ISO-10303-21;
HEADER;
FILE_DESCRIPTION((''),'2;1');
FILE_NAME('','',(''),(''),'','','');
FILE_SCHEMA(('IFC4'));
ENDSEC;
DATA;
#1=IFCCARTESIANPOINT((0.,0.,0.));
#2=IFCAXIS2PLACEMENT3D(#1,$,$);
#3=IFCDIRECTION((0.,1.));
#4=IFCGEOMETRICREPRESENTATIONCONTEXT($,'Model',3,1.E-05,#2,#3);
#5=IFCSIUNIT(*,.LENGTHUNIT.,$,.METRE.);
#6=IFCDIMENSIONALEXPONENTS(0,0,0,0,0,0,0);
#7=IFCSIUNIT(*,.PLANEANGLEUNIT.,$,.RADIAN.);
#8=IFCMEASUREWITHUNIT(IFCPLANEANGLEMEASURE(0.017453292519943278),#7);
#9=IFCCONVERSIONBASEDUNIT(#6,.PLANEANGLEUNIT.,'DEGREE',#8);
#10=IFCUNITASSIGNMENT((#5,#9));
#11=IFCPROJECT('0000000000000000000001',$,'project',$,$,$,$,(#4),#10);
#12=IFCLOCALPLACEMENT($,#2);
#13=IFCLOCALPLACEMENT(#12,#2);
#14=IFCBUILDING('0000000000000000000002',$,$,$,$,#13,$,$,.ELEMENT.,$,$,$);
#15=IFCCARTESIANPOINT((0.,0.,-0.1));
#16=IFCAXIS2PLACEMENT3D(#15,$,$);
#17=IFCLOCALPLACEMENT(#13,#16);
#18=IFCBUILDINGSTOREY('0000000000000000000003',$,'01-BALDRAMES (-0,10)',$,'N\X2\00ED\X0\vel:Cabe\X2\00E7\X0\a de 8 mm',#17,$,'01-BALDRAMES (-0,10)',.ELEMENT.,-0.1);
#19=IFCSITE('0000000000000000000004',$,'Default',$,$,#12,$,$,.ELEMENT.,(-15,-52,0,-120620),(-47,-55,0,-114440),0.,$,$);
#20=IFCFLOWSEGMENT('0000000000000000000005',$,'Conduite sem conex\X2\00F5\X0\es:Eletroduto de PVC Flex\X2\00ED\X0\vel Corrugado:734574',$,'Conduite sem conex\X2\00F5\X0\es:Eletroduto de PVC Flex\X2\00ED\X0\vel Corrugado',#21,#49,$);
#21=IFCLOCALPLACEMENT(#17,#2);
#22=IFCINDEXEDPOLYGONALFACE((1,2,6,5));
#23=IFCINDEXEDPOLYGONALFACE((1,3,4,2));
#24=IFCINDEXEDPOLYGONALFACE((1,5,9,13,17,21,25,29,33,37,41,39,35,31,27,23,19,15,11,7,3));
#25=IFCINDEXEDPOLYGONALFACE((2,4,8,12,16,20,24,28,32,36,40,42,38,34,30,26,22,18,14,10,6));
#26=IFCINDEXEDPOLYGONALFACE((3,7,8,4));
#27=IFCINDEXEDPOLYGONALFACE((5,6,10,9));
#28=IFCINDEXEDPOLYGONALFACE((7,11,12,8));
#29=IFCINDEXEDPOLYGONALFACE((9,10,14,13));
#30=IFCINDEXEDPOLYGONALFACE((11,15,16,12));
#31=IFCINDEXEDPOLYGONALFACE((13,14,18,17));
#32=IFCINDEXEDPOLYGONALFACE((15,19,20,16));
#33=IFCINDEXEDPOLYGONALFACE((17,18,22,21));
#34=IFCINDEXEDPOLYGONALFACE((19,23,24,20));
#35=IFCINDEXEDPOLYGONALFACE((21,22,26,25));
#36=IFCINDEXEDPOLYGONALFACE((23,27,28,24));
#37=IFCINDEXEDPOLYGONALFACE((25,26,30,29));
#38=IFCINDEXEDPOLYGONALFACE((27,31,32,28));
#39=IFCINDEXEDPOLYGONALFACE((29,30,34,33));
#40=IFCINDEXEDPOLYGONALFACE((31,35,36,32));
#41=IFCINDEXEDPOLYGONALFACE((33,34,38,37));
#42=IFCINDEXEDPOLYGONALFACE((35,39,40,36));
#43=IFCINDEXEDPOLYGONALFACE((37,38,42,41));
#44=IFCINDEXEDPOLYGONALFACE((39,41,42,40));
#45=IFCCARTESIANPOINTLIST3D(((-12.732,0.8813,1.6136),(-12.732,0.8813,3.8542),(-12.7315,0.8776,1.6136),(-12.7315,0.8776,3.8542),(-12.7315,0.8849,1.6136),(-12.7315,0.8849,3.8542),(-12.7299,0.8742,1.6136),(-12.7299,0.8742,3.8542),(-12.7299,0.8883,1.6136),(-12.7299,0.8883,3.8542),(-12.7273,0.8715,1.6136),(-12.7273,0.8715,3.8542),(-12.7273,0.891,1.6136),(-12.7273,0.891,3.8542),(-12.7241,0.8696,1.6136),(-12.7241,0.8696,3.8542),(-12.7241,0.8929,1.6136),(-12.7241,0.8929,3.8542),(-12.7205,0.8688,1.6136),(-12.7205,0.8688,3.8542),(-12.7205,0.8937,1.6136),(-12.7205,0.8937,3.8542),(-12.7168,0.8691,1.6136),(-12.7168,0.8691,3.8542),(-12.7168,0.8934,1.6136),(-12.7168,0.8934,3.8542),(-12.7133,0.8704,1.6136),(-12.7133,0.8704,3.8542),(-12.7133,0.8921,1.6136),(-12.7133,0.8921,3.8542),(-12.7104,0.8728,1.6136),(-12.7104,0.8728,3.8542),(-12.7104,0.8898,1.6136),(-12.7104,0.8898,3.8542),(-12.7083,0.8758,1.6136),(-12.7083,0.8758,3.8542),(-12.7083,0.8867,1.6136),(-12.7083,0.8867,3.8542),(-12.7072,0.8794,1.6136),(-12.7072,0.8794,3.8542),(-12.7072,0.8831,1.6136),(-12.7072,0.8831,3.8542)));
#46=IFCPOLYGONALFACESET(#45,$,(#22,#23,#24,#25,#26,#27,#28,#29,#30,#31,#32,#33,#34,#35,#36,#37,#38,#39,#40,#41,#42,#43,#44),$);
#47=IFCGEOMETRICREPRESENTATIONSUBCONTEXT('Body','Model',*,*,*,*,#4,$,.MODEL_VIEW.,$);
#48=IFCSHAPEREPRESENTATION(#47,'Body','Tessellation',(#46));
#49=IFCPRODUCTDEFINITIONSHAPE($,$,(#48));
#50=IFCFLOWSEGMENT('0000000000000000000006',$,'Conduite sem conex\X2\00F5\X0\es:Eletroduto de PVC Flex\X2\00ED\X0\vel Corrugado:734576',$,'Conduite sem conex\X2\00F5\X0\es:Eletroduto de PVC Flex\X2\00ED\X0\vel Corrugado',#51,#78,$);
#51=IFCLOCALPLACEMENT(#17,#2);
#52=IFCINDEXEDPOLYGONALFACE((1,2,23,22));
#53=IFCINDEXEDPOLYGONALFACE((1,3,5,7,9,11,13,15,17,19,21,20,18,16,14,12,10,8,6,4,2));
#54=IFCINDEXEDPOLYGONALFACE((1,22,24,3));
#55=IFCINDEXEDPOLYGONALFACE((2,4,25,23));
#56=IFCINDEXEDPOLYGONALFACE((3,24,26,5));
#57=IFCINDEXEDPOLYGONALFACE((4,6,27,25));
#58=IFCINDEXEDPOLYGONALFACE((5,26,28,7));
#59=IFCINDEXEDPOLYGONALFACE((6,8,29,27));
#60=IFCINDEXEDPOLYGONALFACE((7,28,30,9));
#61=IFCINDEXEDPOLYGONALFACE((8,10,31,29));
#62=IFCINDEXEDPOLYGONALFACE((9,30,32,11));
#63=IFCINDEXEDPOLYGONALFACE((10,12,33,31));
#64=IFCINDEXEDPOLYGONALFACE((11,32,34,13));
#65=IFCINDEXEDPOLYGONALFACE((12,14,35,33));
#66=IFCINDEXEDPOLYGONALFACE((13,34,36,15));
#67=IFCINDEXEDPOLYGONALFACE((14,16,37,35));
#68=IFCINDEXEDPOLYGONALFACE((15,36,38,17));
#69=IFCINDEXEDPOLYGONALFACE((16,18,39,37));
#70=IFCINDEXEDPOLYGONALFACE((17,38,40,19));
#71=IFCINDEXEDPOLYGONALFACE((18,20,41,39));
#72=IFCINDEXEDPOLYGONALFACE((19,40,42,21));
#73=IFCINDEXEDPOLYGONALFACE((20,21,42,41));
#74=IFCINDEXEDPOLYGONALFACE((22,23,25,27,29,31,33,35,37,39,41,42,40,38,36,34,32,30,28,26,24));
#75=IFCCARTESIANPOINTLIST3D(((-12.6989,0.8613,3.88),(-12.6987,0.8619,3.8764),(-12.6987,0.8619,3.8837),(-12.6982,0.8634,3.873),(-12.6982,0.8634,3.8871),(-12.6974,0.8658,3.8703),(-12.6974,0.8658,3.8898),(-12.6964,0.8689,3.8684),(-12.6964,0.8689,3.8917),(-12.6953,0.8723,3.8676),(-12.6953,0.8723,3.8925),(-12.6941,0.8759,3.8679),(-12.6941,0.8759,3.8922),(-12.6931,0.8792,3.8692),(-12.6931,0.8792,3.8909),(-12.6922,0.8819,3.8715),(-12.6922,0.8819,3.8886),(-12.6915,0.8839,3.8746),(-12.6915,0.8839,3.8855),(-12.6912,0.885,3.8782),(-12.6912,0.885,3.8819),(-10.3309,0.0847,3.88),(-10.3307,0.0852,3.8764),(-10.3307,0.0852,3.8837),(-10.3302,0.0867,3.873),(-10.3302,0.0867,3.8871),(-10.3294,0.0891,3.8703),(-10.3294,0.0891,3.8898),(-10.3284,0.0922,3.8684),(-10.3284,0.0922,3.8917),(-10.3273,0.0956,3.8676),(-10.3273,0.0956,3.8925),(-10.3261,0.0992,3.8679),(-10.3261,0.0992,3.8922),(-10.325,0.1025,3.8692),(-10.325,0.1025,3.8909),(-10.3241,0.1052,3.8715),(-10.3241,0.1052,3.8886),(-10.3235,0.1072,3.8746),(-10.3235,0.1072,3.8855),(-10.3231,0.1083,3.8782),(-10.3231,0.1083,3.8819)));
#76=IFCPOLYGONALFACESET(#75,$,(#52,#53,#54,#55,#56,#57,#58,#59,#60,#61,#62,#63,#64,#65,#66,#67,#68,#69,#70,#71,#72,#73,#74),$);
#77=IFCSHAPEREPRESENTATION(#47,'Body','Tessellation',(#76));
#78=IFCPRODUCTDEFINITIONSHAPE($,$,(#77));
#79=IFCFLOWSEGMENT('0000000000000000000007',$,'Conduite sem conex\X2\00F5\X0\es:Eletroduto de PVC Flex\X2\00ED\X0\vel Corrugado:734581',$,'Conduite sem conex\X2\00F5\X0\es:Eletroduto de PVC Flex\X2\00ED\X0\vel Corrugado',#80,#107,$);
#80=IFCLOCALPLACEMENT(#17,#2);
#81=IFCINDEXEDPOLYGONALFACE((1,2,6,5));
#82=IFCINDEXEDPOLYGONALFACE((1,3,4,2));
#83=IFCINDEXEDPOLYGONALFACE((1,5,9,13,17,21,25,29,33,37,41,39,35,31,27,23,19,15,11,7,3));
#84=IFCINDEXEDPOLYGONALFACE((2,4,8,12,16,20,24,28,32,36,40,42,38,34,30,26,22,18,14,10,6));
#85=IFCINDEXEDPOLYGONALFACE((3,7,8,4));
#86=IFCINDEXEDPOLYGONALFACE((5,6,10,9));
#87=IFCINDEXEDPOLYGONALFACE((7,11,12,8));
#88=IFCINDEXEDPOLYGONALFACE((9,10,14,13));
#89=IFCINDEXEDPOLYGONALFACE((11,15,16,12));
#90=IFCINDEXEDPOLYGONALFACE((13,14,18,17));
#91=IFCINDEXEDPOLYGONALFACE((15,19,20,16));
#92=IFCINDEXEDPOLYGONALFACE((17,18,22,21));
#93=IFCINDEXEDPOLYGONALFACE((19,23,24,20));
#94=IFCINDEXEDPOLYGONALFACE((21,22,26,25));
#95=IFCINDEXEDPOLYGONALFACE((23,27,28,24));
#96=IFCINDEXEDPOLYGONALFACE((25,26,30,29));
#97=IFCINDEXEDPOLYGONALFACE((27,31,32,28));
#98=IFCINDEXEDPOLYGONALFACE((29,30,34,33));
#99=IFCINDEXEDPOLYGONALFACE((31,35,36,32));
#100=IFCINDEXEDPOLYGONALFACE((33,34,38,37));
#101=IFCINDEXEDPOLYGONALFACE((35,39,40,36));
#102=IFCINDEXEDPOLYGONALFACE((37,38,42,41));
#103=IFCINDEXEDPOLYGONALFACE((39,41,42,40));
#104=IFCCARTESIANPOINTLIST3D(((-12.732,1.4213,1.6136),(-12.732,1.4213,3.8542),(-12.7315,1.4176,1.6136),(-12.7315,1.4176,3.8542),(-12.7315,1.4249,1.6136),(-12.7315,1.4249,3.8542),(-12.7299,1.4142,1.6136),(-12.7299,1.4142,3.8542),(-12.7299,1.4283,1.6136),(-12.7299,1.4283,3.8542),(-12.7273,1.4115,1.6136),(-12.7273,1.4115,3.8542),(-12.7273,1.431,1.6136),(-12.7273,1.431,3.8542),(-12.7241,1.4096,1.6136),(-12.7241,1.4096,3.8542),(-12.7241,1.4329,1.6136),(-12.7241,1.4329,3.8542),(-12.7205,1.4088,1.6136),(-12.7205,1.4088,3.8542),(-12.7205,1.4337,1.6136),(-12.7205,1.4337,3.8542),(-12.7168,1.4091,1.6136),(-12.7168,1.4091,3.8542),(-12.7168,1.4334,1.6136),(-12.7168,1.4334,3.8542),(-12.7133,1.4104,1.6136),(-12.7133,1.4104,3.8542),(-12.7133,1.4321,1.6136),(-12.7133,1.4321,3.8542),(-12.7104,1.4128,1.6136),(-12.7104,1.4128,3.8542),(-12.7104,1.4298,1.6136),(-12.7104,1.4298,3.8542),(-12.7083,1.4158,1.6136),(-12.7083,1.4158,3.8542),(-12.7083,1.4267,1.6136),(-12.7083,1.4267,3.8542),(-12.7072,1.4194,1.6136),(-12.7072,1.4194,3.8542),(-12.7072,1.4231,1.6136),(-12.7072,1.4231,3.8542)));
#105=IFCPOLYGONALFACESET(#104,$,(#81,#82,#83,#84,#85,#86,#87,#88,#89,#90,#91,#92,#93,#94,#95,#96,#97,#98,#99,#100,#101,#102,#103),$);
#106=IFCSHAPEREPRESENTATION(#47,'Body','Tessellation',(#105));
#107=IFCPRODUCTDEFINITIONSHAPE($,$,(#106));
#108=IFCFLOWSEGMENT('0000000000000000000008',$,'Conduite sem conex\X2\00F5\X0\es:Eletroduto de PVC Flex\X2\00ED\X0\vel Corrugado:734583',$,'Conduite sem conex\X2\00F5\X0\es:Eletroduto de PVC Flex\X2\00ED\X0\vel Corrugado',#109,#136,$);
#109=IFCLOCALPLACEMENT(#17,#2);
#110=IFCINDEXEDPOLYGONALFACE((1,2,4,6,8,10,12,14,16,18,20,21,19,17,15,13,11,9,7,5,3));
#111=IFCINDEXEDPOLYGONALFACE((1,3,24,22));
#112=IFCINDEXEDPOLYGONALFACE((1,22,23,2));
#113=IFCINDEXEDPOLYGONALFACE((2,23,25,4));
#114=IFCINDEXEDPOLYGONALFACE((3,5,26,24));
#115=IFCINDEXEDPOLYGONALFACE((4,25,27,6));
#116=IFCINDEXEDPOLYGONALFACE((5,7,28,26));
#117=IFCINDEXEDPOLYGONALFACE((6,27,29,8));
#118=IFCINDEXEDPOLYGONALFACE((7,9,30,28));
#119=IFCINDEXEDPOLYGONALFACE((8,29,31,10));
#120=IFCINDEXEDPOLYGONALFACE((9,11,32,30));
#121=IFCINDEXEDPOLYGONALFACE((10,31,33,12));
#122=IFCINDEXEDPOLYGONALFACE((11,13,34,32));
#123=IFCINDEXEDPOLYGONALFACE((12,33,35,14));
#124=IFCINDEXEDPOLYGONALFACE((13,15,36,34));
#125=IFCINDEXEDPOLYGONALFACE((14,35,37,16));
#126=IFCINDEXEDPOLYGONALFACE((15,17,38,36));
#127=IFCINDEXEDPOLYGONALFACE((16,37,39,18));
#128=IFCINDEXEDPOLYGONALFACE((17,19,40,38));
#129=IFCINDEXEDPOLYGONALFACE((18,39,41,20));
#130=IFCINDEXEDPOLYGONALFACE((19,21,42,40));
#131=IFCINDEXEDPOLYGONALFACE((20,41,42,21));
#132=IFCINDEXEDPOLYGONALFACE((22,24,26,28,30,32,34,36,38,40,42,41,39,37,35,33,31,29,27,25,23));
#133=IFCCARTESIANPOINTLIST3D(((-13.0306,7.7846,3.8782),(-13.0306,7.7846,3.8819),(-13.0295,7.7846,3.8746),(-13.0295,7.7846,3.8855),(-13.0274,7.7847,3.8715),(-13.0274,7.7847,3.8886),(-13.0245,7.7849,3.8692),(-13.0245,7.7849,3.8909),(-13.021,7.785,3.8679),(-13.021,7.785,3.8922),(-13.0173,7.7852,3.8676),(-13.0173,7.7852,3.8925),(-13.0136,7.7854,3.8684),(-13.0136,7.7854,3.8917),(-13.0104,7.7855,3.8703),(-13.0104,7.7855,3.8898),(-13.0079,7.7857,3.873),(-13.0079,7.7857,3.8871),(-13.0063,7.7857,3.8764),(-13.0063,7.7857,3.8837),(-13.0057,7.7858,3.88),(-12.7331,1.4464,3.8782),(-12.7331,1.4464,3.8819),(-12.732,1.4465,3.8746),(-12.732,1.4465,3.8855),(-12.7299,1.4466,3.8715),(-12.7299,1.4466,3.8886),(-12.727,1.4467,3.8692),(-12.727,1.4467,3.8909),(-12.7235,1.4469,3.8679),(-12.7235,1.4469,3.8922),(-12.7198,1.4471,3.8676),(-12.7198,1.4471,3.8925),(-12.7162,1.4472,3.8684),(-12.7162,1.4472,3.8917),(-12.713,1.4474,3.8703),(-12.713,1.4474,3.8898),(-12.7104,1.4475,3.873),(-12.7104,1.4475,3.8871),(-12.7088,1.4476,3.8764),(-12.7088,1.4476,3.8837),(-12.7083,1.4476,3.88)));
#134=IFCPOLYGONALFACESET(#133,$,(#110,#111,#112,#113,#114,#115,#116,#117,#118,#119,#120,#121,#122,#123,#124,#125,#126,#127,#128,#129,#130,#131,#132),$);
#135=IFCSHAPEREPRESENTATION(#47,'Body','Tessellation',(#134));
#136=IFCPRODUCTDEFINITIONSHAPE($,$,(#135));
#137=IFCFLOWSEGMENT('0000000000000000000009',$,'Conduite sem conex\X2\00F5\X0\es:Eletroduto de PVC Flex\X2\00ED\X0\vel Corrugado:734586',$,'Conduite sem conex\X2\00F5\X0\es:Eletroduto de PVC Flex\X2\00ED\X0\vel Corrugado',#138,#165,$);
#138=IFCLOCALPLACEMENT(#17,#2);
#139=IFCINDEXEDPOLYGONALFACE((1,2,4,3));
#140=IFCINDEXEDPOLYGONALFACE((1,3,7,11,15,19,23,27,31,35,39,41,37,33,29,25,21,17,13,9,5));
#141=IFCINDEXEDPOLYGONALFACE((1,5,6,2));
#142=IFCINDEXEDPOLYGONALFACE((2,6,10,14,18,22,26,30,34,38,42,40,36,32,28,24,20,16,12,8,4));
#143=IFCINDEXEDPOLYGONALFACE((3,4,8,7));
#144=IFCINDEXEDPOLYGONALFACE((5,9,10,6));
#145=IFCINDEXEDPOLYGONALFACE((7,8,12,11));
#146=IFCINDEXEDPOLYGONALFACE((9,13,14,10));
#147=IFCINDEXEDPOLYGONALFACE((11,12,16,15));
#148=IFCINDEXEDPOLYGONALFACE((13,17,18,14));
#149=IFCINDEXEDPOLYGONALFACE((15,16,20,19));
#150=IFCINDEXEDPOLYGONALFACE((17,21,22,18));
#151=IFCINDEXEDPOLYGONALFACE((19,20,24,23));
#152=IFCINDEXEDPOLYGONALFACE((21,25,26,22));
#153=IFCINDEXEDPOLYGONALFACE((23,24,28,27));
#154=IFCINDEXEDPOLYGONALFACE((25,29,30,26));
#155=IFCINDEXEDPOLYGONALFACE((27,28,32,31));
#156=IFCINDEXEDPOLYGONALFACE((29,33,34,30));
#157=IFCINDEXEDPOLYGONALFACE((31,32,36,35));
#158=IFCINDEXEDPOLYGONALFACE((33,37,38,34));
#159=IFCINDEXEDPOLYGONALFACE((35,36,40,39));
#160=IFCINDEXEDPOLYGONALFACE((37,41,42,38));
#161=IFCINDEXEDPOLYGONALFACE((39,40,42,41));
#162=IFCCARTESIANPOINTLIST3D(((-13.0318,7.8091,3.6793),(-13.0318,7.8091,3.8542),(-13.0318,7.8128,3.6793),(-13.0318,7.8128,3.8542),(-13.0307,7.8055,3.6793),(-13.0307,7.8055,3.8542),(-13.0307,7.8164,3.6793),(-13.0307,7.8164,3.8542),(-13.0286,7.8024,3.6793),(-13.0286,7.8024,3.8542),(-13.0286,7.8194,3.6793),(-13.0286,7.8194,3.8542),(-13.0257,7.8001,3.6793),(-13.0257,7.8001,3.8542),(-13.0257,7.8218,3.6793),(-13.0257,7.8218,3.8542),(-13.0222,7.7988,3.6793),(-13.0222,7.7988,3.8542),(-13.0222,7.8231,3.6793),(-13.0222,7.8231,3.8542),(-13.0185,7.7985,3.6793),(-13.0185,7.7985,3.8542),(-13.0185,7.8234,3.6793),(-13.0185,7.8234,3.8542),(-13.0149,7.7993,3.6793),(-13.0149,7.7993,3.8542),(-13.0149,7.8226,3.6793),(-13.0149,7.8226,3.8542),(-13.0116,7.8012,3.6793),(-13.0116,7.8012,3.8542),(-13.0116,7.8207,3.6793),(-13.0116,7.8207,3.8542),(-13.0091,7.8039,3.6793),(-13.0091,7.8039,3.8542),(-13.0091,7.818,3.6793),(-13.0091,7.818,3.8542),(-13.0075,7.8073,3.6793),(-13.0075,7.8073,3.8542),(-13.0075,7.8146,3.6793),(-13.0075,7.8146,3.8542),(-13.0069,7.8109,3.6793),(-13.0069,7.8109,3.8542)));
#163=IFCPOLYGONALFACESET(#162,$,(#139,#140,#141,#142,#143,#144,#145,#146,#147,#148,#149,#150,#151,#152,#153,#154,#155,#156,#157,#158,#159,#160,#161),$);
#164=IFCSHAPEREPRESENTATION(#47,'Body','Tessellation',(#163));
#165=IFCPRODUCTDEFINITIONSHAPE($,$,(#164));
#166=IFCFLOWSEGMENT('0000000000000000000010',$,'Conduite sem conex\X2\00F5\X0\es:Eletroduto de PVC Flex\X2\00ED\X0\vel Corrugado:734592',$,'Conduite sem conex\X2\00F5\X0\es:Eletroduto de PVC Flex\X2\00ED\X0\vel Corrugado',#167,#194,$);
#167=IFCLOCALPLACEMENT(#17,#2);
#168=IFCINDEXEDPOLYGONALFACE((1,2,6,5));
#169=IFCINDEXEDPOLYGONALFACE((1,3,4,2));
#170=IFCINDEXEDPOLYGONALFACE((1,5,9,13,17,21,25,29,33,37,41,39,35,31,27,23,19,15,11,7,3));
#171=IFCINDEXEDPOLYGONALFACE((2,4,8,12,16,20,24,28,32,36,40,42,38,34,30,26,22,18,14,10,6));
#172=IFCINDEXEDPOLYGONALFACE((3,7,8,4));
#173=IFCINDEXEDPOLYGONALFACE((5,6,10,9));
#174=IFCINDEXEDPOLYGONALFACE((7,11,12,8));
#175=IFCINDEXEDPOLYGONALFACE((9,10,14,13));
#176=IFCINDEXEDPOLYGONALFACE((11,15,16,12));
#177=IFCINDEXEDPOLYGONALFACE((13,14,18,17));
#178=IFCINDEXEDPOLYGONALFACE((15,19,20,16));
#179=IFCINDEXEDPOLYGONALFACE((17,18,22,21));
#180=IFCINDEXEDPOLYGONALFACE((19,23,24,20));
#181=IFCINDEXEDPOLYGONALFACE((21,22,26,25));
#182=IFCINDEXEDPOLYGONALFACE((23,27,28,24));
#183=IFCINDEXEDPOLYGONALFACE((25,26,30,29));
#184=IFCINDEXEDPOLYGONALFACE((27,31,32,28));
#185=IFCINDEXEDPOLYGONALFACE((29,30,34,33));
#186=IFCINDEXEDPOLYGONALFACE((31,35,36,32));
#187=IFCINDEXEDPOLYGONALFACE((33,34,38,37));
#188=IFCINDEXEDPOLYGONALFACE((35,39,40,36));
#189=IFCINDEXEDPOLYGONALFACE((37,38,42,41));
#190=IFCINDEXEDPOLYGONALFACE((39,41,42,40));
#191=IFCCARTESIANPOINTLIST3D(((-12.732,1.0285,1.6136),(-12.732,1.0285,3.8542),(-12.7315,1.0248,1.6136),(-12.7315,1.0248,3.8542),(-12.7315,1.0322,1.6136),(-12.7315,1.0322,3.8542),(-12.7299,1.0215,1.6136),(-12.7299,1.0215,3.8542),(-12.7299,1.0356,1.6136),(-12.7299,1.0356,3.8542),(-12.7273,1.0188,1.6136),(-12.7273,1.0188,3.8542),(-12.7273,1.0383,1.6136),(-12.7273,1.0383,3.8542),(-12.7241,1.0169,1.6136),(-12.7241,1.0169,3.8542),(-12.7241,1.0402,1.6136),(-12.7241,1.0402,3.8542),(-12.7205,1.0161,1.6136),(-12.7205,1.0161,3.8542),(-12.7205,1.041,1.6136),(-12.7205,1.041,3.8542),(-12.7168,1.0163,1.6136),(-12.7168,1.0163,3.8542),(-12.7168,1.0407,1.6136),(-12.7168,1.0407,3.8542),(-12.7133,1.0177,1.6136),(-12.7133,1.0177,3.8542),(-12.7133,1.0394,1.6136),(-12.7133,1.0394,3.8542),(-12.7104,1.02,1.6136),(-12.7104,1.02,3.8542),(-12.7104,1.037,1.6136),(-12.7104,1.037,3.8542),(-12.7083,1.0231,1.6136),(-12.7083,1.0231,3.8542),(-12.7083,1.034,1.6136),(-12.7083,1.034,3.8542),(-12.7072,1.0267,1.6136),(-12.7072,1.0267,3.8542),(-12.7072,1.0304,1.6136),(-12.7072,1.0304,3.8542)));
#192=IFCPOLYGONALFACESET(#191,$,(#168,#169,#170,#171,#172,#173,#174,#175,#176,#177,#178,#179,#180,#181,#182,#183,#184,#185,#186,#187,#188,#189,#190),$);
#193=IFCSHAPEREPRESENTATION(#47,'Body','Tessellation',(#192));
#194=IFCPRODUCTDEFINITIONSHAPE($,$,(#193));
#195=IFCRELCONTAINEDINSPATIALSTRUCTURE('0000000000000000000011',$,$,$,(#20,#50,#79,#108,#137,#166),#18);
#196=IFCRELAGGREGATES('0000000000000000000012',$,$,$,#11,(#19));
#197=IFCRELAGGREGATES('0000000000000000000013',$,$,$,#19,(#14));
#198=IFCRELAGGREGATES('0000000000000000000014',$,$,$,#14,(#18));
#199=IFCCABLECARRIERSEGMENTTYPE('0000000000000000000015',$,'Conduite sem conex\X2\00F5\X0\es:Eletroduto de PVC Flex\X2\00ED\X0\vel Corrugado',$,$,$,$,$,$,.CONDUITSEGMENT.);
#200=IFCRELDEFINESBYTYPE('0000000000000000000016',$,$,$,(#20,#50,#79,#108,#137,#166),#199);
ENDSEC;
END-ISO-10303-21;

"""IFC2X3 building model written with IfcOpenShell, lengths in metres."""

from ifc_helpers import new_model, entity, si_unit, converted_unit, direction, frame, frame_2d, origin, origin_2d_with_axis, place, context, subcontext, project, spatial, circle, extrude, type_object, element, save


model = new_model("IFC2X3")

# Units and contexts
model_context = context("Model", 3, precision=1e-05, world=origin(), true_north=direction((0.0, 1.0)))
body_context = subcontext(model_context, "Body", "Model", "MODEL_VIEW")
ifc_project = project(units=[si_unit("LENGTHUNIT", "METRE"), converted_unit("PLANEANGLEUNIT", "DEGREE", entity("IfcPlaneAngleMeasure", 0.017453292519943278), si_unit("PLANEANGLEUNIT", "RADIAN"), dimensions=[0, 0, 0, 0, 0, 0, 0])], contexts=[model_context])

# Site, building, storey
site_placement = place(None, origin())
site = spatial("IfcSite", under=ifc_project, at=site_placement, Name="Default", CompositionType="ELEMENT", RefLatitude=(-15, -52, 0, -120620), RefLongitude=(-47, -55, 0, -114440), RefElevation=0.0)
building_placement = place(site_placement, origin())
building = spatial("IfcBuilding", under=site, at=building_placement, CompositionType="ELEMENT")
storey_placement = place(building_placement, frame((0.0, 0.0, -0.1)))
storey = spatial("IfcBuildingStorey", under=building, at=storey_placement, Name="01-BALDRAMES (-0,10)", ObjectType="Nível:Cabeça de 8 mm", LongName="01-BALDRAMES (-0,10)", CompositionType="ELEMENT", Elevation=-0.1)

# Flow segments
cable_carrier_segment_type = type_object("IfcCableCarrierSegmentType", Name="Conduite sem conexões:Eletroduto de PVC Flexível Corrugado", PredefinedType="CONDUITSEGMENT")
flow_segment_1_placement = place(storey_placement, origin())
element("IfcFlowSegment", 1, at=flow_segment_1_placement, inside=storey, type_object=cable_carrier_segment_type, Name="Conduite sem conexões:Eletroduto de PVC Flexível Corrugado:734574", ObjectType="Conduite sem conexões:Eletroduto de PVC Flexível Corrugado", context=body_context, shape_type="SweptSolid", body=[
    extrude(circle(Radius=0.0125, at=frame_2d((0.0, 0.0), x_axis=(1.0, 0.0))), frame((-12.7195, 0.8813, 1.6136), z_axis=(0.0, 0.0, 1.0), x_axis=(-1.0, 0.0, 0.0)), (0.0, 0.0, 1.0), 2.2406),
])
flow_segment_2_placement = place(storey_placement, origin())
element("IfcFlowSegment", 2, at=flow_segment_2_placement, inside=storey, type_object=cable_carrier_segment_type, Name="Conduite sem conexões:Eletroduto de PVC Flexível Corrugado:734576", ObjectType="Conduite sem conexões:Eletroduto de PVC Flexível Corrugado", context=body_context, shape_type="SweptSolid", body=[
    extrude(circle(Radius=0.0125, at=frame_2d((0.0, 0.0), x_axis=(1.0, 0.0))), frame((-12.695, 0.8732, 3.88), z_axis=(0.950198, -0.311648, 0.0), x_axis=(-0.311648, -0.950198, 0.0)), (0.0, 0.0, 1.0), 2.4922),
])
flow_segment_3_placement = place(storey_placement, origin())
element("IfcFlowSegment", 3, at=flow_segment_3_placement, inside=storey, type_object=cable_carrier_segment_type, Name="Conduite sem conexões:Eletroduto de PVC Flexível Corrugado:734581", ObjectType="Conduite sem conexões:Eletroduto de PVC Flexível Corrugado", context=body_context, shape_type="SweptSolid", body=[
    extrude(circle(Radius=0.0125, at=origin_2d_with_axis()), frame((-12.7195, 1.4213, 1.6136), z_axis=(0.0, 0.0, 1.0), x_axis=(-1.0, 0.0, 0.0)), (0.0, 0.0, 1.0), 2.2406),
])
flow_segment_4_placement = place(storey_placement, origin())
element("IfcFlowSegment", 4, at=flow_segment_4_placement, inside=storey, type_object=cable_carrier_segment_type, Name="Conduite sem conexões:Eletroduto de PVC Flexível Corrugado:734583", ObjectType="Conduite sem conexões:Eletroduto de PVC Flexível Corrugado", context=body_context, shape_type="SweptSolid", body=[
    extrude(circle(Radius=0.0125, at=frame_2d((0.0, 0.0), x_axis=(1.0, 0.0))), frame((-13.0182, 7.7852, 3.88), z_axis=(0.046881, -0.9989, 0.0), x_axis=(0.9989, 0.046881, 0.0)), (0.0, 0.0, 1.0), 6.3451),
])
flow_segment_5_placement = place(storey_placement, origin())
element("IfcFlowSegment", 5, at=flow_segment_5_placement, inside=storey, type_object=cable_carrier_segment_type, Name="Conduite sem conexões:Eletroduto de PVC Flexível Corrugado:734586", ObjectType="Conduite sem conexões:Eletroduto de PVC Flexível Corrugado", context=body_context, shape_type="SweptSolid", body=[
    extrude(circle(Radius=0.0125, at=origin_2d_with_axis()), frame((-13.0194, 7.8109, 3.6793)), (0.0, 0.0, 1.0), 0.1749),
])
flow_segment_6_placement = place(storey_placement, origin())
element("IfcFlowSegment", 6, at=flow_segment_6_placement, inside=storey, type_object=cable_carrier_segment_type, Name="Conduite sem conexões:Eletroduto de PVC Flexível Corrugado:734592", ObjectType="Conduite sem conexões:Eletroduto de PVC Flexível Corrugado", context=body_context, shape_type="SweptSolid", body=[
    extrude(circle(Radius=0.0125, at=frame_2d((0.0, 0.0), x_axis=(1.0, 0.0))), frame((-12.7195, 1.0285, 1.6136), z_axis=(0.0, 0.0, 1.0), x_axis=(-1.0, 0.0, 0.0)), (0.0, 0.0, 1.0), 2.2406),
])

save(model, "model.ifc")
